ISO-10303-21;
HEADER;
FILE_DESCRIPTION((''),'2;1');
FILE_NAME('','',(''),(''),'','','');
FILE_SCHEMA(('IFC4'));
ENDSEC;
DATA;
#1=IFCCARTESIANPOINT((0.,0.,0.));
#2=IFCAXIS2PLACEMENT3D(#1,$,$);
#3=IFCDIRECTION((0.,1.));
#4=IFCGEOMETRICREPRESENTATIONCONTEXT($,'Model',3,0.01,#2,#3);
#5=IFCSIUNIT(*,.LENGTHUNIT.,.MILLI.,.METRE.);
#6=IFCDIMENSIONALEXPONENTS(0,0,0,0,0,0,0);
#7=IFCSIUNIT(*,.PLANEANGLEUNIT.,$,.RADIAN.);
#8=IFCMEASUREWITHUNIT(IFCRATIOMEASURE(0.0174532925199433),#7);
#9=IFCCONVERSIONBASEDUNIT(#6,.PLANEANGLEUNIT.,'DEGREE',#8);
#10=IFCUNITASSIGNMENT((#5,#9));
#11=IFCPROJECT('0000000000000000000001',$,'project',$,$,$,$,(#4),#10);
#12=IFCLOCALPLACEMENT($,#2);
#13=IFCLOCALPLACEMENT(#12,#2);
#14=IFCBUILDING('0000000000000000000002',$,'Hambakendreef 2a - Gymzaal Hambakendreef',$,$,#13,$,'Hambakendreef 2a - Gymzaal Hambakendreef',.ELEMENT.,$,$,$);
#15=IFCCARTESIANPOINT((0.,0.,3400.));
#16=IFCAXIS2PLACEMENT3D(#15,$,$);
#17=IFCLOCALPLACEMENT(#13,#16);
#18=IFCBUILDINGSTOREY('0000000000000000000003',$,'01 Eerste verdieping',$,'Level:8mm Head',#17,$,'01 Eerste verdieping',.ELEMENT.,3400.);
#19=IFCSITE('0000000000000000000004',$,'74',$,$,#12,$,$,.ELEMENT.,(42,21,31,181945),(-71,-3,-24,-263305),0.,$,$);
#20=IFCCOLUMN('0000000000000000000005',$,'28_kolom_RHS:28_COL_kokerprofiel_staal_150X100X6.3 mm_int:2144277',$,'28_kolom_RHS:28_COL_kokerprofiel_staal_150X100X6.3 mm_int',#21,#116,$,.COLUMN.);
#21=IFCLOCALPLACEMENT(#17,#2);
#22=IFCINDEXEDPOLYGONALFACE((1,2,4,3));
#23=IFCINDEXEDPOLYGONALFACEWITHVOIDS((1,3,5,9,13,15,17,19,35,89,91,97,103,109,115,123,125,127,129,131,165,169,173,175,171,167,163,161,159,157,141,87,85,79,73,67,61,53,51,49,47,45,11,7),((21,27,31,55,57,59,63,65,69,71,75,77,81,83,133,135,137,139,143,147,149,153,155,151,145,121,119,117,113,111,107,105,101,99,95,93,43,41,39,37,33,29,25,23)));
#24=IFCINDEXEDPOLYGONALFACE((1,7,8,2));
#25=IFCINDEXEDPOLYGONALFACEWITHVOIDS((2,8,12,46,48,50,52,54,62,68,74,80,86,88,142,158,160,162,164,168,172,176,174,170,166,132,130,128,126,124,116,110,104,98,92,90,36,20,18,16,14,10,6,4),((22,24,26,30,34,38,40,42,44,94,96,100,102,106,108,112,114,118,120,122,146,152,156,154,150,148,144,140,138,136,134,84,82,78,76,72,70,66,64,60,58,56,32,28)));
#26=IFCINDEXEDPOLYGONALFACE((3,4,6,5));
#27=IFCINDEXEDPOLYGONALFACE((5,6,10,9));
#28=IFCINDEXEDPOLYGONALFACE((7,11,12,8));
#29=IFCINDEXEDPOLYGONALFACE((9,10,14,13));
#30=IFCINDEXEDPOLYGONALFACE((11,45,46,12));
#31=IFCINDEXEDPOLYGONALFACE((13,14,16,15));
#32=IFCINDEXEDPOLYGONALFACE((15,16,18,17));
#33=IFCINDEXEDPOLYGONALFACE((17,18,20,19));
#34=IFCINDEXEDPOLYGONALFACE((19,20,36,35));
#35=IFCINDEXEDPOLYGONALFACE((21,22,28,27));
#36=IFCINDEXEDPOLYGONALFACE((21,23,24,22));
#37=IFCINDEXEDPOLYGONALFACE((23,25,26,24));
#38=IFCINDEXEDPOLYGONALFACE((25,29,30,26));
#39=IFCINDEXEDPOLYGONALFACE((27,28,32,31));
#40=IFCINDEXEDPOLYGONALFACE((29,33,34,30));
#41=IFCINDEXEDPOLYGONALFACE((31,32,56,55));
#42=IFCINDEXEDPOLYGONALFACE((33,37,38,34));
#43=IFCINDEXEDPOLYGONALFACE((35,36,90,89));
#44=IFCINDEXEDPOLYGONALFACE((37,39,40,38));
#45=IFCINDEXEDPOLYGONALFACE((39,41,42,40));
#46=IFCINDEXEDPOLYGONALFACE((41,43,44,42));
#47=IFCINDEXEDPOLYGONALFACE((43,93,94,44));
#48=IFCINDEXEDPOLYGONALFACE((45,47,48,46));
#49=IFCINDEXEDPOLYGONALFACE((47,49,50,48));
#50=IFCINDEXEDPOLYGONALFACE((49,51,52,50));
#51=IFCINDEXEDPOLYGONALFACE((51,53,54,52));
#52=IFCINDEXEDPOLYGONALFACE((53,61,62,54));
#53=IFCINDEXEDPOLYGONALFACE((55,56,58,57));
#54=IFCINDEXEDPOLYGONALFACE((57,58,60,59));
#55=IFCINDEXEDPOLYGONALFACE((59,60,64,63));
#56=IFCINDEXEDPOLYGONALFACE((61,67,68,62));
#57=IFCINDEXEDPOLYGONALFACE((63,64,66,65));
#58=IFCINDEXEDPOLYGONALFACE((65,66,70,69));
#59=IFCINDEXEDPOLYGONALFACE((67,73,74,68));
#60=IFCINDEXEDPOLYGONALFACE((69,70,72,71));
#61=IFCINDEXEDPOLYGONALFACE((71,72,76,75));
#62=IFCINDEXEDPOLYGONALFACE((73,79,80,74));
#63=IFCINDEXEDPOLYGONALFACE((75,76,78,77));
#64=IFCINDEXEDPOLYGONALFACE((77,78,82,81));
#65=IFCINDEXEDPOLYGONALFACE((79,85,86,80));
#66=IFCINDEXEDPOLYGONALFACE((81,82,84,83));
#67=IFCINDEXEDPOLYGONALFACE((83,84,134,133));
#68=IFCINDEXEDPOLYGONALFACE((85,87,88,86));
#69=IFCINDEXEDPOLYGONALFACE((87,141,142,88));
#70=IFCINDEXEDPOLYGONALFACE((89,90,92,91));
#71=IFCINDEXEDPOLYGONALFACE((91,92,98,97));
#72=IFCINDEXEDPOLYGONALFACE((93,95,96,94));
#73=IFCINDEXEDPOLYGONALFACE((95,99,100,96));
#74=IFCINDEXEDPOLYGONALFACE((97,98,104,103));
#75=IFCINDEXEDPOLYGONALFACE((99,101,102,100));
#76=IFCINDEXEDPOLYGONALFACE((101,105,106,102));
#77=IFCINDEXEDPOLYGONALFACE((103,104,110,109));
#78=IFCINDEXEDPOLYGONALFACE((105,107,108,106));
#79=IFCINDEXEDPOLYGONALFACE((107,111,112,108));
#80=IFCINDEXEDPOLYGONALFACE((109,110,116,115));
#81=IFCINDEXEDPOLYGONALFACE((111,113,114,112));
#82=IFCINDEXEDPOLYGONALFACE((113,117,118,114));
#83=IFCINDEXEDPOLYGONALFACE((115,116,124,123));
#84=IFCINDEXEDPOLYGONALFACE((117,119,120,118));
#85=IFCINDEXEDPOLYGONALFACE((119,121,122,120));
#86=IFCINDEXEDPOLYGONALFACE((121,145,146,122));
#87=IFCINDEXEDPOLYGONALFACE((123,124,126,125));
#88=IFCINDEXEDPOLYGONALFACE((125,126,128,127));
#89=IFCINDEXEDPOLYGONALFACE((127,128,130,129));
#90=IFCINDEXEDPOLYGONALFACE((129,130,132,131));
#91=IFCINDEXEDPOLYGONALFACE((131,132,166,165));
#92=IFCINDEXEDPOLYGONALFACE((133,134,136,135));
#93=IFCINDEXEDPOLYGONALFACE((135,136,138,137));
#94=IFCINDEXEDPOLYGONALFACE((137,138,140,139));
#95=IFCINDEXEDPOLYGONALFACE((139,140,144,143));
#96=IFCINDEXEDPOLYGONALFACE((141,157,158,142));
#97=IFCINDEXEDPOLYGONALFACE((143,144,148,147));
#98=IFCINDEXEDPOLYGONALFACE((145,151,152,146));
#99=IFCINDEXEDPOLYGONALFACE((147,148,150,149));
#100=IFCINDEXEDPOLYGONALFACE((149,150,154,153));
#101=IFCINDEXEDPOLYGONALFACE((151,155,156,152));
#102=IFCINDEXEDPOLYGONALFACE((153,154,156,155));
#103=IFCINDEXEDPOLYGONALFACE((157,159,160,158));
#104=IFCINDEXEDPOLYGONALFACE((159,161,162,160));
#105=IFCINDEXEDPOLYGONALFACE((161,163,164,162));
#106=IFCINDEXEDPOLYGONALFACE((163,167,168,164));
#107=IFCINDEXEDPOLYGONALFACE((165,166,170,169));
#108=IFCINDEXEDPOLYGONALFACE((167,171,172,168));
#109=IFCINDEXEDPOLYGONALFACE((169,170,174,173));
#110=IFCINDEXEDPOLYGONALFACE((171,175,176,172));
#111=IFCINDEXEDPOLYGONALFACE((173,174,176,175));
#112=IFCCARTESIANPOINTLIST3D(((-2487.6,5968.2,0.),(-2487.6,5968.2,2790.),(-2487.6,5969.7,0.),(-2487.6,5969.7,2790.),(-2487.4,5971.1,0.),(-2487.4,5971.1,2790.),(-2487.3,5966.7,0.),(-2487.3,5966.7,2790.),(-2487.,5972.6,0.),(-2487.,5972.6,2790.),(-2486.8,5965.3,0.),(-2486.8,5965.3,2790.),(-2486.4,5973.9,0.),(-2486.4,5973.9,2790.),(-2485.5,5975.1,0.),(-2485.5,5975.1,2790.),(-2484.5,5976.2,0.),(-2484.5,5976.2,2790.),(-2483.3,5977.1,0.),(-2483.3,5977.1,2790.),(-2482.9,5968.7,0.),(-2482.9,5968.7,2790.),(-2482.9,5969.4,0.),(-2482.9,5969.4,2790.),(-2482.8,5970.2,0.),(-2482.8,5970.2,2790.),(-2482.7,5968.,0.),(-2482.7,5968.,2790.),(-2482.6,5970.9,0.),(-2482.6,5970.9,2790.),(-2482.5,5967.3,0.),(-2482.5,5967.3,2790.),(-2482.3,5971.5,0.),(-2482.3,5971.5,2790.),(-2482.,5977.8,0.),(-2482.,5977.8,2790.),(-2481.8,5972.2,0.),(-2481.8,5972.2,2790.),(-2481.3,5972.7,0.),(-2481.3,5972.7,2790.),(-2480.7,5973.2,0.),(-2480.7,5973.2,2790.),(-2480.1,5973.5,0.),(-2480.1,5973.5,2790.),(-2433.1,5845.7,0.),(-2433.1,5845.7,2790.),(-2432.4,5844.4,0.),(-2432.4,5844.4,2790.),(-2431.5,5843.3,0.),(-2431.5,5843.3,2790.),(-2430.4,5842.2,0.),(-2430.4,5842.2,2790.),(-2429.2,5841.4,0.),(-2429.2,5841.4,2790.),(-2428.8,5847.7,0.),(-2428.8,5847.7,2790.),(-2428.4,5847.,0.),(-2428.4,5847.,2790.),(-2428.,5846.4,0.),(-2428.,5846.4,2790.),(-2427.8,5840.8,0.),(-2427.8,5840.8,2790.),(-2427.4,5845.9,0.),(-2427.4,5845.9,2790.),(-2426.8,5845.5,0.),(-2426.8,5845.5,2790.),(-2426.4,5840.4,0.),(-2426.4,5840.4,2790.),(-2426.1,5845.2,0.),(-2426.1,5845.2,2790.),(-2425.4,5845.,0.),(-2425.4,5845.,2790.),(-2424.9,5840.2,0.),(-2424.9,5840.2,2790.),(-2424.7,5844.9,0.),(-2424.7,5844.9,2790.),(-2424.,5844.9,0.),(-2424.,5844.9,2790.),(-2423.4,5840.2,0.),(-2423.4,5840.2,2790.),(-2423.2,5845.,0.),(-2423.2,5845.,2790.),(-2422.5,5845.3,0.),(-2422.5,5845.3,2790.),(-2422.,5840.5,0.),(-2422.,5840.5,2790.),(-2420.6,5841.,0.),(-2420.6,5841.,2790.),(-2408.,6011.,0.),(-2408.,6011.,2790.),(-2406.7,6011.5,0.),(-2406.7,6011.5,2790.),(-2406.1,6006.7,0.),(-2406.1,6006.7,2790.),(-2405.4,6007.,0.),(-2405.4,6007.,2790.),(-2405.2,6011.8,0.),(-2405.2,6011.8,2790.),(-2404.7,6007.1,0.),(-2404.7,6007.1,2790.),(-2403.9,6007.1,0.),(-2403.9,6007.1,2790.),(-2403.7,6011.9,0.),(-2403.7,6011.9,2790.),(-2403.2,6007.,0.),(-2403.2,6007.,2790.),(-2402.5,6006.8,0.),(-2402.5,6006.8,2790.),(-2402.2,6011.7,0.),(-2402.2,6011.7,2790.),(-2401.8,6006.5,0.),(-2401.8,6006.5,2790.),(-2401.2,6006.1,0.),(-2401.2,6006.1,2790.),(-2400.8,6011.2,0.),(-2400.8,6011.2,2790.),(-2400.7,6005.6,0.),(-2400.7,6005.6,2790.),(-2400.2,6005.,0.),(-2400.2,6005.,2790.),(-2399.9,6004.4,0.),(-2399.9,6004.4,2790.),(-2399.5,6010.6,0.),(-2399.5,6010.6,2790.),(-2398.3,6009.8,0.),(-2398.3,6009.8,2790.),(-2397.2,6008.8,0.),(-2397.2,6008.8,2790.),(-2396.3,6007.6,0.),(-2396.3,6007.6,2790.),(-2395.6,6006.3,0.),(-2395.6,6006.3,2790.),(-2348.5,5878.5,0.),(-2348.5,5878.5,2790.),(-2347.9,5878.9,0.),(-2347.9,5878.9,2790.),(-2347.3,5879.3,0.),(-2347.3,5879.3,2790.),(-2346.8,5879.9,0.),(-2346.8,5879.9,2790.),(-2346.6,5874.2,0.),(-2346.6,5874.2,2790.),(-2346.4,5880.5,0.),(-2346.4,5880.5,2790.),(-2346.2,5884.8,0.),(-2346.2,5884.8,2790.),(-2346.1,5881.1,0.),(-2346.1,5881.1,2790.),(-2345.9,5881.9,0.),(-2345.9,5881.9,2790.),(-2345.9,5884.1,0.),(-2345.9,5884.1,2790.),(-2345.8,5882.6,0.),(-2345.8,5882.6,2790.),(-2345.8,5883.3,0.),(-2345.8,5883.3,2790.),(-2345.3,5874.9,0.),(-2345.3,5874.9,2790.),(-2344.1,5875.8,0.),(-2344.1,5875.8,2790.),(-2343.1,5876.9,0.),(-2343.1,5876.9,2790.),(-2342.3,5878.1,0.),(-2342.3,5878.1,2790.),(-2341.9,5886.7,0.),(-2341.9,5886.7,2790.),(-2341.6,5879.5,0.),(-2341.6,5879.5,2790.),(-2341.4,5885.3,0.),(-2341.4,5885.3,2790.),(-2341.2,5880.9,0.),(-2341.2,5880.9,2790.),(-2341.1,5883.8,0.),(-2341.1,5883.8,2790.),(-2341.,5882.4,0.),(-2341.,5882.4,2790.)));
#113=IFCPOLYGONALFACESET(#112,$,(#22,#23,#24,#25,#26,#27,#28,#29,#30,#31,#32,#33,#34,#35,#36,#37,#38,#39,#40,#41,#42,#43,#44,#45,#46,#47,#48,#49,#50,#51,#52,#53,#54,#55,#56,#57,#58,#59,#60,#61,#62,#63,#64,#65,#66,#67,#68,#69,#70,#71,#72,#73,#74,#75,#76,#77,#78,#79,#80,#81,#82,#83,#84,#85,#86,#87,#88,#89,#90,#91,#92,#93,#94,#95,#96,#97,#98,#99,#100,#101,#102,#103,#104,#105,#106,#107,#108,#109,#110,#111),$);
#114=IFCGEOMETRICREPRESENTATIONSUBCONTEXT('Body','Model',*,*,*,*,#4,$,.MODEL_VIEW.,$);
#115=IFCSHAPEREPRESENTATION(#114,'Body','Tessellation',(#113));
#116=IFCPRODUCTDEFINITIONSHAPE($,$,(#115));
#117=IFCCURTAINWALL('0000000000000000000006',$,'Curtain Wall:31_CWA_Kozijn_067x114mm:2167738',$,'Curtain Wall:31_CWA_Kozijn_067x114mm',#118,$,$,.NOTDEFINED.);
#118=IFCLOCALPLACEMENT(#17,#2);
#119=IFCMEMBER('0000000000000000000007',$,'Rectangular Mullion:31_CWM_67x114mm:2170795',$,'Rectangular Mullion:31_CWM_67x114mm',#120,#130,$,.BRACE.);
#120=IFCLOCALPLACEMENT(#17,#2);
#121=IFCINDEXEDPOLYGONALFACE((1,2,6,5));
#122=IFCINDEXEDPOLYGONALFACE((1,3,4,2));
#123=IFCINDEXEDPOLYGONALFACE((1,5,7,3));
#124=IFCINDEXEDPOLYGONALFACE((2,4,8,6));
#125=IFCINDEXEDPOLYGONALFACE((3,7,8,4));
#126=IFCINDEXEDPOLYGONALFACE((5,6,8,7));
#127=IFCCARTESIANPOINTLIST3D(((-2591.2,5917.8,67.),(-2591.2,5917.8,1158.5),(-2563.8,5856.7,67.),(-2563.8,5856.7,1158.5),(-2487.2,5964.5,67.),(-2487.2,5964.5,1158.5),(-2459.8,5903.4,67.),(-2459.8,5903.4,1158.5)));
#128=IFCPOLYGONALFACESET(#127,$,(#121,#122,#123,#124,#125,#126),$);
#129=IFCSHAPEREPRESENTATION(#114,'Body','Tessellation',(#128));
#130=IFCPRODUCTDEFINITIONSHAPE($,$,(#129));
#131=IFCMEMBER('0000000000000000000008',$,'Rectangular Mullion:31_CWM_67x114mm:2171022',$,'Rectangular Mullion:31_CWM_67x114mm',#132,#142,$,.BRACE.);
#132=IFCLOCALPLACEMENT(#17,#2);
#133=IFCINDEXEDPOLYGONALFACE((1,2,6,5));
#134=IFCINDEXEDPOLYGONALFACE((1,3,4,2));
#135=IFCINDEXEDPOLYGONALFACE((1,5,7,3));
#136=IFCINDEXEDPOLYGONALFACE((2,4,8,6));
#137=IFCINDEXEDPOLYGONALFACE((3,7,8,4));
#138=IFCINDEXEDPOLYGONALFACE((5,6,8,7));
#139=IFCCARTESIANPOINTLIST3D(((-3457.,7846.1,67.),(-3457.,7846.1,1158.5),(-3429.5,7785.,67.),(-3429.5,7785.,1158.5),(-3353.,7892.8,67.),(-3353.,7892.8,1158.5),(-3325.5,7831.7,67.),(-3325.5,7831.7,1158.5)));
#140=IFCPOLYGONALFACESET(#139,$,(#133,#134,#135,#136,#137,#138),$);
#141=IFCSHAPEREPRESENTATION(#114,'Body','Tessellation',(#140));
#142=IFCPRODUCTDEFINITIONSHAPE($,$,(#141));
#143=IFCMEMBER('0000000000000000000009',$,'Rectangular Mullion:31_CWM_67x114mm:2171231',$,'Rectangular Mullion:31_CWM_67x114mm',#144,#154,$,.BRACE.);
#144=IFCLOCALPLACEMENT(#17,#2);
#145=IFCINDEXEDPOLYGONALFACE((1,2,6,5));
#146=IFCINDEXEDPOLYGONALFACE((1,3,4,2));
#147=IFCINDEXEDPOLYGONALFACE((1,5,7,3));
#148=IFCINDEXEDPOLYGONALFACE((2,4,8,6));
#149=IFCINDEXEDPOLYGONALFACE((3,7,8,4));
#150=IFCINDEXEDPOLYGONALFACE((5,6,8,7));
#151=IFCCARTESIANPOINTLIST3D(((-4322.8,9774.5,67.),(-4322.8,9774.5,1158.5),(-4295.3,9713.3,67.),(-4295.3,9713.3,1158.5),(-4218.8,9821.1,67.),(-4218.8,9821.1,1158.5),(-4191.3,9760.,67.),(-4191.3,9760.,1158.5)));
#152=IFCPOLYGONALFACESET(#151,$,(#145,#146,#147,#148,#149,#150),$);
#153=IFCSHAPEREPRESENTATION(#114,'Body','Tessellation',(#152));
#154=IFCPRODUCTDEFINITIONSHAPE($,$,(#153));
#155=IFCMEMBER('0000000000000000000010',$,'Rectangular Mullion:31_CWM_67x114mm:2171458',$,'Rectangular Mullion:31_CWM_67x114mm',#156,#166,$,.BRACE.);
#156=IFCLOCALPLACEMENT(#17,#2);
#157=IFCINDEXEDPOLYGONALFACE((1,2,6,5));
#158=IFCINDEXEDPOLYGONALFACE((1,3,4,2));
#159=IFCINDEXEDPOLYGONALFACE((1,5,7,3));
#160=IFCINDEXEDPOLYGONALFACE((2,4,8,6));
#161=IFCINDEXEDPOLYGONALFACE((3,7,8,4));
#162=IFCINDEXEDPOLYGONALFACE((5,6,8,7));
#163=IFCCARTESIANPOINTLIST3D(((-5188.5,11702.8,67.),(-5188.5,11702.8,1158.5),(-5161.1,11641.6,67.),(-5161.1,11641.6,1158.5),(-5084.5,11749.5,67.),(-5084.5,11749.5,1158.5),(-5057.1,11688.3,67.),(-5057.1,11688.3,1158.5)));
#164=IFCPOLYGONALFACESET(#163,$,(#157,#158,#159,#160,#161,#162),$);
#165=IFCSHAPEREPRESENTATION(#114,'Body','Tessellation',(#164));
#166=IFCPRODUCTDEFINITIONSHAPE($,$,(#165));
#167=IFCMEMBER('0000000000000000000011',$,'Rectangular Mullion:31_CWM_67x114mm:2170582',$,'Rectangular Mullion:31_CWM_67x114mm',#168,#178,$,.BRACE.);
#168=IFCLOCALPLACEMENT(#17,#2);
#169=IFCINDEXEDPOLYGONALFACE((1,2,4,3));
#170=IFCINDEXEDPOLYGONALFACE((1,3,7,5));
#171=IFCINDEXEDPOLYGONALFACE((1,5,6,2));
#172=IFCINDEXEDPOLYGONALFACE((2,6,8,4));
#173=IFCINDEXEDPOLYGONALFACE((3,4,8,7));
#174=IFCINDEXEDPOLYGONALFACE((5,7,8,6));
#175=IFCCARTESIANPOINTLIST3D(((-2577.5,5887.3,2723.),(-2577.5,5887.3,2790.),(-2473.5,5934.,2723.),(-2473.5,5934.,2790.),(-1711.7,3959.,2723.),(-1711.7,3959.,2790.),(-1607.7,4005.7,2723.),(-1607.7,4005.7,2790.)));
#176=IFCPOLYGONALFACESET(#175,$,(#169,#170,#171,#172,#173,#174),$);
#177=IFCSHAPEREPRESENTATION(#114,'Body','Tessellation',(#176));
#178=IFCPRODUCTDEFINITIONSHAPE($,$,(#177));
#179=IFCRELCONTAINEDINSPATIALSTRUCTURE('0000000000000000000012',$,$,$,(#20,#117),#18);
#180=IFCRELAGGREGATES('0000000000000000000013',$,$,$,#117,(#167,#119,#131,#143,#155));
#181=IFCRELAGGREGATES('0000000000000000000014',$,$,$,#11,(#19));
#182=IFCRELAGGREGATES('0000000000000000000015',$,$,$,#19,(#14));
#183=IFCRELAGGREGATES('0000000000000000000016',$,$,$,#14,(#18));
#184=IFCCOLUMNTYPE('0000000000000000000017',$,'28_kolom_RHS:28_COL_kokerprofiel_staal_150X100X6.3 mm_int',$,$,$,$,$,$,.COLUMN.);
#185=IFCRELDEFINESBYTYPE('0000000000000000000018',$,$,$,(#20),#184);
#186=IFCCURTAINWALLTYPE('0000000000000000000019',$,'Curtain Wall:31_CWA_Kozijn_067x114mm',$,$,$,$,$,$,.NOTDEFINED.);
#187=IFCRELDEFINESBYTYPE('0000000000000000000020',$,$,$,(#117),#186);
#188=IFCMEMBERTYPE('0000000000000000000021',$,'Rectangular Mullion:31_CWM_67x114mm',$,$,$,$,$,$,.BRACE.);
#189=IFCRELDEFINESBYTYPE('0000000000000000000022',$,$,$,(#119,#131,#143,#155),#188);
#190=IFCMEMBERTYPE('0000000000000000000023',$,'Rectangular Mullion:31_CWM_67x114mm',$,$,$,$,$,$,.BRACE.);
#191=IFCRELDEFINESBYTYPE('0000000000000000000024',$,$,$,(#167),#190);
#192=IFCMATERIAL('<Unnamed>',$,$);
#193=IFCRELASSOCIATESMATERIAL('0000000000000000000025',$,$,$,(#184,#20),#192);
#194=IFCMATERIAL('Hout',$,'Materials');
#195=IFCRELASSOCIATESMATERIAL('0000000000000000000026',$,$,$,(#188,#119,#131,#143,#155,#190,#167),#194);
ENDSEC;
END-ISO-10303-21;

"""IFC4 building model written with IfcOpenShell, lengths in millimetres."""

from ifc_helpers import new_model, entity, si_unit, converted_unit, direction, frame, origin, place, context, subcontext, project, spatial, indexed_curve, outline, extrude, source, transform, mapped, material, type_object, type_shapes, element, aggregate, save


model = new_model("IFC4")

# Units and contexts
model_context = context("Model", 3, precision=0.01, world=origin(), true_north=direction((0.0, 1.0)))
body_context = subcontext(model_context, "Body", "Model", "MODEL_VIEW")
ifc_project = project(units=[si_unit("LENGTHUNIT", "METRE", prefix="MILLI"), converted_unit("PLANEANGLEUNIT", "DEGREE", entity("IfcRatioMeasure", 0.0174532925199433), si_unit("PLANEANGLEUNIT", "RADIAN"), dimensions=[0, 0, 0, 0, 0, 0, 0])], contexts=[model_context])

# Site, building, storey
site_placement = place(None, origin())
site = spatial("IfcSite", under=ifc_project, at=site_placement, Name="74", CompositionType="ELEMENT", RefLatitude=(42, 21, 31, 181945), RefLongitude=(-71, -3, -24, -263305), RefElevation=0.0)
building_placement = place(site_placement, origin())
building = spatial("IfcBuilding", under=site, at=building_placement, Name="Hambakendreef 2a - Gymzaal Hambakendreef", LongName="Hambakendreef 2a - Gymzaal Hambakendreef", CompositionType="ELEMENT")
storey_placement = place(building_placement, frame((0.0, 0.0, 3400.0)))
storey = spatial("IfcBuildingStorey", under=building, at=storey_placement, Name="01 Eerste verdieping", ObjectType="Level:8mm Head", LongName="01 Eerste verdieping", CompositionType="ELEMENT", Elevation=3400.0)

# Column
ifc_material_1 = material(Name="<Unnamed>")
column_type = type_object("IfcColumnType", Name="28_kolom_RHS:28_COL_kokerprofiel_staal_150X100X6.3 mm_int", PredefinedType="COLUMN", material=ifc_material_1)
shared_shape_1 = source(origin(), body_context, "Body", "SweptSolid", [
    extrude(outline(indexed_curve([(-40.5, -75.0), (40.5, -75.0), (42.0, -74.9), (43.5, -74.5), (44.8, -74.0), (46.1, -73.2), (47.2, -72.2), (48.2, -71.1), (49.0, -69.8), (49.5, -68.5), (49.9, -67.0), (50.0, -65.6), (50.0, 65.6), (49.9, 67.0), (49.5, 68.5), (49.0, 69.8), (48.2, 71.1), (47.2, 72.2), (46.1, 73.2), (44.8, 74.0), (43.5, 74.5), (42.0, 74.9), (40.5, 75.0), (-40.5, 75.0), (-42.0, 74.9), (-43.5, 74.5), (-44.8, 74.0), (-46.1, 73.2), (-47.2, 72.2), (-48.2, 71.1), (-49.0, 69.8), (-49.5, 68.5), (-49.9, 67.0), (-50.0, 65.6), (-50.0, -65.6), (-49.9, -67.0), (-49.5, -68.5), (-49.0, -69.8), (-48.2, -71.1), (-47.2, -72.2), (-46.1, -73.2), (-44.8, -74.0), (-43.5, -74.5), (-42.0, -74.9), (-40.5, -75.0)], self_intersect=False), holes=[indexed_curve([(-45.3, 65.5), (-45.2, 66.3), (-45.0, 67.0), (-44.8, 67.7), (-44.4, 68.3), (-43.9, 68.9), (-43.3, 69.4), (-42.7, 69.8), (-42.0, 70.0), (-41.3, 70.2), (-40.6, 70.3), (40.5, 70.3), (41.3, 70.2), (42.0, 70.0), (42.7, 69.8), (43.3, 69.4), (43.9, 68.9), (44.4, 68.3), (44.8, 67.7), (45.0, 67.0), (45.2, 66.3), (45.3, 65.5), (45.3, -65.5), (45.2, -66.3), (45.0, -67.0), (44.8, -67.7), (44.4, -68.3), (43.9, -68.9), (43.3, -69.4), (42.7, -69.8), (42.0, -70.0), (41.3, -70.2), (40.5, -70.3), (-40.6, -70.3), (-41.3, -70.2), (-42.0, -70.0), (-42.7, -69.8), (-43.3, -69.4), (-43.9, -68.9), (-44.4, -68.3), (-44.8, -67.7), (-45.0, -67.0), (-45.2, -66.3), (-45.3, -65.5), (-45.3, 65.5)], self_intersect=False)]), frame((235.6, 34.3, 3400.0), z_axis=(0.0, 0.0, 1.0), x_axis=(0.0, 1.0, 0.0)), (0.0, 0.0, 1.0), 2790.0),
])
type_shapes(column_type, [shared_shape_1])
for number, where, z_axis, x_axis, name in (
    (1, (-2542.1, 6126.9, -3400.0), (0.0, 0.0, 1.0), (0.40959, -0.91227, 0.0), "28_kolom_RHS:28_COL_kokerprofiel_staal_150X100X6.3 mm_int:2144277"),
):
    element("IfcColumn", number, at=place(storey_placement, frame(where, z_axis=z_axis, x_axis=x_axis)), inside=storey, type_object=column_type, material=ifc_material_1, Name=name, ObjectType="28_kolom_RHS:28_COL_kokerprofiel_staal_150X100X6.3 mm_int", PredefinedType="COLUMN", context=body_context, shape_type="MappedRepresentation", body=[
        mapped(shared_shape_1, transform((0.0, 0.0, 0.0), scale=1.0)),
    ])

# Curtain wall, members
curtain_wall_type = type_object("IfcCurtainWallType", Name="Curtain Wall:31_CWA_Kozijn_067x114mm", PredefinedType="NOTDEFINED")
curtain_wall_placement = place(storey_placement, frame((0.0, 0.0, -3400.0)))
curtain_wall = element("IfcCurtainWall", 2, at=curtain_wall_placement, inside=storey, type_object=curtain_wall_type, Name="Curtain Wall:31_CWA_Kozijn_067x114mm:2167738", ObjectType="Curtain Wall:31_CWA_Kozijn_067x114mm", PredefinedType="NOTDEFINED")
ifc_material_2 = material(Name="Hout", Category="Materials")
member_type_1 = type_object("IfcMemberType", Name="Rectangular Mullion:31_CWM_67x114mm", PredefinedType="BRACE", material=ifc_material_2)
shared_shape_2 = source(origin(), body_context, "Body", "SweptSolid", [
    extrude(outline(indexed_curve([(-57.0, -33.5), (57.0, -33.5), (57.0, 33.5), (-57.0, 33.5), (-57.0, -33.5)], self_intersect=False)), frame((0.0, 0.0, -1091.5), z_axis=(0.0, 0.0, 1.0), x_axis=(0.0, -1.0, 0.0)), (0.0, 0.0, 1.0), 1091.5),
])
type_shapes(member_type_1, [shared_shape_2])
member_1_placement = place(storey_placement, frame((-2525.5, 5910.6, 67.0), z_axis=(0.0, 0.0, -1.0), x_axis=(0.40959, -0.91227, 0.0)))
member_1 = element("IfcMember", 3, at=member_1_placement, type_object=member_type_1, material=ifc_material_2, Name="Rectangular Mullion:31_CWM_67x114mm:2170795", ObjectType="Rectangular Mullion:31_CWM_67x114mm", PredefinedType="BRACE", context=body_context, shape_type="MappedRepresentation", body=[
    mapped(shared_shape_2, transform((0.0, 0.0, 0.0), scale=1.0)),
])
member_2_placement = place(storey_placement, frame((-3391.3, 7838.9, 67.0), z_axis=(0.0, 0.0, -1.0), x_axis=(0.40959, -0.91227, 0.0)))
member_2 = element("IfcMember", 4, at=member_2_placement, type_object=member_type_1, material=ifc_material_2, Name="Rectangular Mullion:31_CWM_67x114mm:2171022", ObjectType="Rectangular Mullion:31_CWM_67x114mm", PredefinedType="BRACE", context=body_context, shape_type="MappedRepresentation", body=[
    mapped(shared_shape_2, transform((0.0, 0.0, 0.0), scale=1.0)),
])
member_3_placement = place(storey_placement, frame((-4257.0, 9767.2, 67.0), z_axis=(0.0, 0.0, -1.0), x_axis=(0.40959, -0.91227, 0.0)))
member_3 = element("IfcMember", 5, at=member_3_placement, type_object=member_type_1, material=ifc_material_2, Name="Rectangular Mullion:31_CWM_67x114mm:2171231", ObjectType="Rectangular Mullion:31_CWM_67x114mm", PredefinedType="BRACE", context=body_context, shape_type="MappedRepresentation", body=[
    mapped(shared_shape_2, transform((0.0, 0.0, 0.0), scale=1.0)),
])
member_4_placement = place(storey_placement, frame((-5122.8, 11695.6, 67.0), z_axis=(0.0, 0.0, -1.0), x_axis=(0.40959, -0.91227, 0.0)))
member_4 = element("IfcMember", 6, at=member_4_placement, type_object=member_type_1, material=ifc_material_2, Name="Rectangular Mullion:31_CWM_67x114mm:2171458", ObjectType="Rectangular Mullion:31_CWM_67x114mm", PredefinedType="BRACE", context=body_context, shape_type="MappedRepresentation", body=[
    mapped(shared_shape_2, transform((0.0, 0.0, 0.0), scale=1.0)),
])
member_type_2 = type_object("IfcMemberType", Name="Rectangular Mullion:31_CWM_67x114mm", PredefinedType="BRACE", material=ifc_material_2)
shared_shape_3 = source(origin(), body_context, "Body", "SweptSolid", [
    extrude(outline(indexed_curve([(-57.0, -33.5), (57.0, -33.5), (57.0, 33.5), (-57.0, 33.5), (-57.0, -33.5)], self_intersect=False)), frame((-33.5, 0.0, -2113.8), z_axis=(0.0, 0.0, 1.0), x_axis=(0.0, -1.0, 0.0)), (0.0, 0.0, 1.0), 2113.8),
])
type_shapes(member_type_2, [shared_shape_3])
member_5_placement = place(storey_placement, frame((-1659.7, 3982.3, 2790.0), z_axis=(0.40959, -0.91227, 0.0), x_axis=(0.0, 0.0, 1.0)))
member_5 = element("IfcMember", 7, at=member_5_placement, type_object=member_type_2, material=ifc_material_2, Name="Rectangular Mullion:31_CWM_67x114mm:2170582", ObjectType="Rectangular Mullion:31_CWM_67x114mm", PredefinedType="BRACE", context=body_context, shape_type="MappedRepresentation", body=[
    mapped(shared_shape_3, transform((0.0, 0.0, 0.0), scale=1.0)),
])
aggregate(curtain_wall, [member_5, member_1, member_2, member_3, member_4])

save(model, "model.ifc")
